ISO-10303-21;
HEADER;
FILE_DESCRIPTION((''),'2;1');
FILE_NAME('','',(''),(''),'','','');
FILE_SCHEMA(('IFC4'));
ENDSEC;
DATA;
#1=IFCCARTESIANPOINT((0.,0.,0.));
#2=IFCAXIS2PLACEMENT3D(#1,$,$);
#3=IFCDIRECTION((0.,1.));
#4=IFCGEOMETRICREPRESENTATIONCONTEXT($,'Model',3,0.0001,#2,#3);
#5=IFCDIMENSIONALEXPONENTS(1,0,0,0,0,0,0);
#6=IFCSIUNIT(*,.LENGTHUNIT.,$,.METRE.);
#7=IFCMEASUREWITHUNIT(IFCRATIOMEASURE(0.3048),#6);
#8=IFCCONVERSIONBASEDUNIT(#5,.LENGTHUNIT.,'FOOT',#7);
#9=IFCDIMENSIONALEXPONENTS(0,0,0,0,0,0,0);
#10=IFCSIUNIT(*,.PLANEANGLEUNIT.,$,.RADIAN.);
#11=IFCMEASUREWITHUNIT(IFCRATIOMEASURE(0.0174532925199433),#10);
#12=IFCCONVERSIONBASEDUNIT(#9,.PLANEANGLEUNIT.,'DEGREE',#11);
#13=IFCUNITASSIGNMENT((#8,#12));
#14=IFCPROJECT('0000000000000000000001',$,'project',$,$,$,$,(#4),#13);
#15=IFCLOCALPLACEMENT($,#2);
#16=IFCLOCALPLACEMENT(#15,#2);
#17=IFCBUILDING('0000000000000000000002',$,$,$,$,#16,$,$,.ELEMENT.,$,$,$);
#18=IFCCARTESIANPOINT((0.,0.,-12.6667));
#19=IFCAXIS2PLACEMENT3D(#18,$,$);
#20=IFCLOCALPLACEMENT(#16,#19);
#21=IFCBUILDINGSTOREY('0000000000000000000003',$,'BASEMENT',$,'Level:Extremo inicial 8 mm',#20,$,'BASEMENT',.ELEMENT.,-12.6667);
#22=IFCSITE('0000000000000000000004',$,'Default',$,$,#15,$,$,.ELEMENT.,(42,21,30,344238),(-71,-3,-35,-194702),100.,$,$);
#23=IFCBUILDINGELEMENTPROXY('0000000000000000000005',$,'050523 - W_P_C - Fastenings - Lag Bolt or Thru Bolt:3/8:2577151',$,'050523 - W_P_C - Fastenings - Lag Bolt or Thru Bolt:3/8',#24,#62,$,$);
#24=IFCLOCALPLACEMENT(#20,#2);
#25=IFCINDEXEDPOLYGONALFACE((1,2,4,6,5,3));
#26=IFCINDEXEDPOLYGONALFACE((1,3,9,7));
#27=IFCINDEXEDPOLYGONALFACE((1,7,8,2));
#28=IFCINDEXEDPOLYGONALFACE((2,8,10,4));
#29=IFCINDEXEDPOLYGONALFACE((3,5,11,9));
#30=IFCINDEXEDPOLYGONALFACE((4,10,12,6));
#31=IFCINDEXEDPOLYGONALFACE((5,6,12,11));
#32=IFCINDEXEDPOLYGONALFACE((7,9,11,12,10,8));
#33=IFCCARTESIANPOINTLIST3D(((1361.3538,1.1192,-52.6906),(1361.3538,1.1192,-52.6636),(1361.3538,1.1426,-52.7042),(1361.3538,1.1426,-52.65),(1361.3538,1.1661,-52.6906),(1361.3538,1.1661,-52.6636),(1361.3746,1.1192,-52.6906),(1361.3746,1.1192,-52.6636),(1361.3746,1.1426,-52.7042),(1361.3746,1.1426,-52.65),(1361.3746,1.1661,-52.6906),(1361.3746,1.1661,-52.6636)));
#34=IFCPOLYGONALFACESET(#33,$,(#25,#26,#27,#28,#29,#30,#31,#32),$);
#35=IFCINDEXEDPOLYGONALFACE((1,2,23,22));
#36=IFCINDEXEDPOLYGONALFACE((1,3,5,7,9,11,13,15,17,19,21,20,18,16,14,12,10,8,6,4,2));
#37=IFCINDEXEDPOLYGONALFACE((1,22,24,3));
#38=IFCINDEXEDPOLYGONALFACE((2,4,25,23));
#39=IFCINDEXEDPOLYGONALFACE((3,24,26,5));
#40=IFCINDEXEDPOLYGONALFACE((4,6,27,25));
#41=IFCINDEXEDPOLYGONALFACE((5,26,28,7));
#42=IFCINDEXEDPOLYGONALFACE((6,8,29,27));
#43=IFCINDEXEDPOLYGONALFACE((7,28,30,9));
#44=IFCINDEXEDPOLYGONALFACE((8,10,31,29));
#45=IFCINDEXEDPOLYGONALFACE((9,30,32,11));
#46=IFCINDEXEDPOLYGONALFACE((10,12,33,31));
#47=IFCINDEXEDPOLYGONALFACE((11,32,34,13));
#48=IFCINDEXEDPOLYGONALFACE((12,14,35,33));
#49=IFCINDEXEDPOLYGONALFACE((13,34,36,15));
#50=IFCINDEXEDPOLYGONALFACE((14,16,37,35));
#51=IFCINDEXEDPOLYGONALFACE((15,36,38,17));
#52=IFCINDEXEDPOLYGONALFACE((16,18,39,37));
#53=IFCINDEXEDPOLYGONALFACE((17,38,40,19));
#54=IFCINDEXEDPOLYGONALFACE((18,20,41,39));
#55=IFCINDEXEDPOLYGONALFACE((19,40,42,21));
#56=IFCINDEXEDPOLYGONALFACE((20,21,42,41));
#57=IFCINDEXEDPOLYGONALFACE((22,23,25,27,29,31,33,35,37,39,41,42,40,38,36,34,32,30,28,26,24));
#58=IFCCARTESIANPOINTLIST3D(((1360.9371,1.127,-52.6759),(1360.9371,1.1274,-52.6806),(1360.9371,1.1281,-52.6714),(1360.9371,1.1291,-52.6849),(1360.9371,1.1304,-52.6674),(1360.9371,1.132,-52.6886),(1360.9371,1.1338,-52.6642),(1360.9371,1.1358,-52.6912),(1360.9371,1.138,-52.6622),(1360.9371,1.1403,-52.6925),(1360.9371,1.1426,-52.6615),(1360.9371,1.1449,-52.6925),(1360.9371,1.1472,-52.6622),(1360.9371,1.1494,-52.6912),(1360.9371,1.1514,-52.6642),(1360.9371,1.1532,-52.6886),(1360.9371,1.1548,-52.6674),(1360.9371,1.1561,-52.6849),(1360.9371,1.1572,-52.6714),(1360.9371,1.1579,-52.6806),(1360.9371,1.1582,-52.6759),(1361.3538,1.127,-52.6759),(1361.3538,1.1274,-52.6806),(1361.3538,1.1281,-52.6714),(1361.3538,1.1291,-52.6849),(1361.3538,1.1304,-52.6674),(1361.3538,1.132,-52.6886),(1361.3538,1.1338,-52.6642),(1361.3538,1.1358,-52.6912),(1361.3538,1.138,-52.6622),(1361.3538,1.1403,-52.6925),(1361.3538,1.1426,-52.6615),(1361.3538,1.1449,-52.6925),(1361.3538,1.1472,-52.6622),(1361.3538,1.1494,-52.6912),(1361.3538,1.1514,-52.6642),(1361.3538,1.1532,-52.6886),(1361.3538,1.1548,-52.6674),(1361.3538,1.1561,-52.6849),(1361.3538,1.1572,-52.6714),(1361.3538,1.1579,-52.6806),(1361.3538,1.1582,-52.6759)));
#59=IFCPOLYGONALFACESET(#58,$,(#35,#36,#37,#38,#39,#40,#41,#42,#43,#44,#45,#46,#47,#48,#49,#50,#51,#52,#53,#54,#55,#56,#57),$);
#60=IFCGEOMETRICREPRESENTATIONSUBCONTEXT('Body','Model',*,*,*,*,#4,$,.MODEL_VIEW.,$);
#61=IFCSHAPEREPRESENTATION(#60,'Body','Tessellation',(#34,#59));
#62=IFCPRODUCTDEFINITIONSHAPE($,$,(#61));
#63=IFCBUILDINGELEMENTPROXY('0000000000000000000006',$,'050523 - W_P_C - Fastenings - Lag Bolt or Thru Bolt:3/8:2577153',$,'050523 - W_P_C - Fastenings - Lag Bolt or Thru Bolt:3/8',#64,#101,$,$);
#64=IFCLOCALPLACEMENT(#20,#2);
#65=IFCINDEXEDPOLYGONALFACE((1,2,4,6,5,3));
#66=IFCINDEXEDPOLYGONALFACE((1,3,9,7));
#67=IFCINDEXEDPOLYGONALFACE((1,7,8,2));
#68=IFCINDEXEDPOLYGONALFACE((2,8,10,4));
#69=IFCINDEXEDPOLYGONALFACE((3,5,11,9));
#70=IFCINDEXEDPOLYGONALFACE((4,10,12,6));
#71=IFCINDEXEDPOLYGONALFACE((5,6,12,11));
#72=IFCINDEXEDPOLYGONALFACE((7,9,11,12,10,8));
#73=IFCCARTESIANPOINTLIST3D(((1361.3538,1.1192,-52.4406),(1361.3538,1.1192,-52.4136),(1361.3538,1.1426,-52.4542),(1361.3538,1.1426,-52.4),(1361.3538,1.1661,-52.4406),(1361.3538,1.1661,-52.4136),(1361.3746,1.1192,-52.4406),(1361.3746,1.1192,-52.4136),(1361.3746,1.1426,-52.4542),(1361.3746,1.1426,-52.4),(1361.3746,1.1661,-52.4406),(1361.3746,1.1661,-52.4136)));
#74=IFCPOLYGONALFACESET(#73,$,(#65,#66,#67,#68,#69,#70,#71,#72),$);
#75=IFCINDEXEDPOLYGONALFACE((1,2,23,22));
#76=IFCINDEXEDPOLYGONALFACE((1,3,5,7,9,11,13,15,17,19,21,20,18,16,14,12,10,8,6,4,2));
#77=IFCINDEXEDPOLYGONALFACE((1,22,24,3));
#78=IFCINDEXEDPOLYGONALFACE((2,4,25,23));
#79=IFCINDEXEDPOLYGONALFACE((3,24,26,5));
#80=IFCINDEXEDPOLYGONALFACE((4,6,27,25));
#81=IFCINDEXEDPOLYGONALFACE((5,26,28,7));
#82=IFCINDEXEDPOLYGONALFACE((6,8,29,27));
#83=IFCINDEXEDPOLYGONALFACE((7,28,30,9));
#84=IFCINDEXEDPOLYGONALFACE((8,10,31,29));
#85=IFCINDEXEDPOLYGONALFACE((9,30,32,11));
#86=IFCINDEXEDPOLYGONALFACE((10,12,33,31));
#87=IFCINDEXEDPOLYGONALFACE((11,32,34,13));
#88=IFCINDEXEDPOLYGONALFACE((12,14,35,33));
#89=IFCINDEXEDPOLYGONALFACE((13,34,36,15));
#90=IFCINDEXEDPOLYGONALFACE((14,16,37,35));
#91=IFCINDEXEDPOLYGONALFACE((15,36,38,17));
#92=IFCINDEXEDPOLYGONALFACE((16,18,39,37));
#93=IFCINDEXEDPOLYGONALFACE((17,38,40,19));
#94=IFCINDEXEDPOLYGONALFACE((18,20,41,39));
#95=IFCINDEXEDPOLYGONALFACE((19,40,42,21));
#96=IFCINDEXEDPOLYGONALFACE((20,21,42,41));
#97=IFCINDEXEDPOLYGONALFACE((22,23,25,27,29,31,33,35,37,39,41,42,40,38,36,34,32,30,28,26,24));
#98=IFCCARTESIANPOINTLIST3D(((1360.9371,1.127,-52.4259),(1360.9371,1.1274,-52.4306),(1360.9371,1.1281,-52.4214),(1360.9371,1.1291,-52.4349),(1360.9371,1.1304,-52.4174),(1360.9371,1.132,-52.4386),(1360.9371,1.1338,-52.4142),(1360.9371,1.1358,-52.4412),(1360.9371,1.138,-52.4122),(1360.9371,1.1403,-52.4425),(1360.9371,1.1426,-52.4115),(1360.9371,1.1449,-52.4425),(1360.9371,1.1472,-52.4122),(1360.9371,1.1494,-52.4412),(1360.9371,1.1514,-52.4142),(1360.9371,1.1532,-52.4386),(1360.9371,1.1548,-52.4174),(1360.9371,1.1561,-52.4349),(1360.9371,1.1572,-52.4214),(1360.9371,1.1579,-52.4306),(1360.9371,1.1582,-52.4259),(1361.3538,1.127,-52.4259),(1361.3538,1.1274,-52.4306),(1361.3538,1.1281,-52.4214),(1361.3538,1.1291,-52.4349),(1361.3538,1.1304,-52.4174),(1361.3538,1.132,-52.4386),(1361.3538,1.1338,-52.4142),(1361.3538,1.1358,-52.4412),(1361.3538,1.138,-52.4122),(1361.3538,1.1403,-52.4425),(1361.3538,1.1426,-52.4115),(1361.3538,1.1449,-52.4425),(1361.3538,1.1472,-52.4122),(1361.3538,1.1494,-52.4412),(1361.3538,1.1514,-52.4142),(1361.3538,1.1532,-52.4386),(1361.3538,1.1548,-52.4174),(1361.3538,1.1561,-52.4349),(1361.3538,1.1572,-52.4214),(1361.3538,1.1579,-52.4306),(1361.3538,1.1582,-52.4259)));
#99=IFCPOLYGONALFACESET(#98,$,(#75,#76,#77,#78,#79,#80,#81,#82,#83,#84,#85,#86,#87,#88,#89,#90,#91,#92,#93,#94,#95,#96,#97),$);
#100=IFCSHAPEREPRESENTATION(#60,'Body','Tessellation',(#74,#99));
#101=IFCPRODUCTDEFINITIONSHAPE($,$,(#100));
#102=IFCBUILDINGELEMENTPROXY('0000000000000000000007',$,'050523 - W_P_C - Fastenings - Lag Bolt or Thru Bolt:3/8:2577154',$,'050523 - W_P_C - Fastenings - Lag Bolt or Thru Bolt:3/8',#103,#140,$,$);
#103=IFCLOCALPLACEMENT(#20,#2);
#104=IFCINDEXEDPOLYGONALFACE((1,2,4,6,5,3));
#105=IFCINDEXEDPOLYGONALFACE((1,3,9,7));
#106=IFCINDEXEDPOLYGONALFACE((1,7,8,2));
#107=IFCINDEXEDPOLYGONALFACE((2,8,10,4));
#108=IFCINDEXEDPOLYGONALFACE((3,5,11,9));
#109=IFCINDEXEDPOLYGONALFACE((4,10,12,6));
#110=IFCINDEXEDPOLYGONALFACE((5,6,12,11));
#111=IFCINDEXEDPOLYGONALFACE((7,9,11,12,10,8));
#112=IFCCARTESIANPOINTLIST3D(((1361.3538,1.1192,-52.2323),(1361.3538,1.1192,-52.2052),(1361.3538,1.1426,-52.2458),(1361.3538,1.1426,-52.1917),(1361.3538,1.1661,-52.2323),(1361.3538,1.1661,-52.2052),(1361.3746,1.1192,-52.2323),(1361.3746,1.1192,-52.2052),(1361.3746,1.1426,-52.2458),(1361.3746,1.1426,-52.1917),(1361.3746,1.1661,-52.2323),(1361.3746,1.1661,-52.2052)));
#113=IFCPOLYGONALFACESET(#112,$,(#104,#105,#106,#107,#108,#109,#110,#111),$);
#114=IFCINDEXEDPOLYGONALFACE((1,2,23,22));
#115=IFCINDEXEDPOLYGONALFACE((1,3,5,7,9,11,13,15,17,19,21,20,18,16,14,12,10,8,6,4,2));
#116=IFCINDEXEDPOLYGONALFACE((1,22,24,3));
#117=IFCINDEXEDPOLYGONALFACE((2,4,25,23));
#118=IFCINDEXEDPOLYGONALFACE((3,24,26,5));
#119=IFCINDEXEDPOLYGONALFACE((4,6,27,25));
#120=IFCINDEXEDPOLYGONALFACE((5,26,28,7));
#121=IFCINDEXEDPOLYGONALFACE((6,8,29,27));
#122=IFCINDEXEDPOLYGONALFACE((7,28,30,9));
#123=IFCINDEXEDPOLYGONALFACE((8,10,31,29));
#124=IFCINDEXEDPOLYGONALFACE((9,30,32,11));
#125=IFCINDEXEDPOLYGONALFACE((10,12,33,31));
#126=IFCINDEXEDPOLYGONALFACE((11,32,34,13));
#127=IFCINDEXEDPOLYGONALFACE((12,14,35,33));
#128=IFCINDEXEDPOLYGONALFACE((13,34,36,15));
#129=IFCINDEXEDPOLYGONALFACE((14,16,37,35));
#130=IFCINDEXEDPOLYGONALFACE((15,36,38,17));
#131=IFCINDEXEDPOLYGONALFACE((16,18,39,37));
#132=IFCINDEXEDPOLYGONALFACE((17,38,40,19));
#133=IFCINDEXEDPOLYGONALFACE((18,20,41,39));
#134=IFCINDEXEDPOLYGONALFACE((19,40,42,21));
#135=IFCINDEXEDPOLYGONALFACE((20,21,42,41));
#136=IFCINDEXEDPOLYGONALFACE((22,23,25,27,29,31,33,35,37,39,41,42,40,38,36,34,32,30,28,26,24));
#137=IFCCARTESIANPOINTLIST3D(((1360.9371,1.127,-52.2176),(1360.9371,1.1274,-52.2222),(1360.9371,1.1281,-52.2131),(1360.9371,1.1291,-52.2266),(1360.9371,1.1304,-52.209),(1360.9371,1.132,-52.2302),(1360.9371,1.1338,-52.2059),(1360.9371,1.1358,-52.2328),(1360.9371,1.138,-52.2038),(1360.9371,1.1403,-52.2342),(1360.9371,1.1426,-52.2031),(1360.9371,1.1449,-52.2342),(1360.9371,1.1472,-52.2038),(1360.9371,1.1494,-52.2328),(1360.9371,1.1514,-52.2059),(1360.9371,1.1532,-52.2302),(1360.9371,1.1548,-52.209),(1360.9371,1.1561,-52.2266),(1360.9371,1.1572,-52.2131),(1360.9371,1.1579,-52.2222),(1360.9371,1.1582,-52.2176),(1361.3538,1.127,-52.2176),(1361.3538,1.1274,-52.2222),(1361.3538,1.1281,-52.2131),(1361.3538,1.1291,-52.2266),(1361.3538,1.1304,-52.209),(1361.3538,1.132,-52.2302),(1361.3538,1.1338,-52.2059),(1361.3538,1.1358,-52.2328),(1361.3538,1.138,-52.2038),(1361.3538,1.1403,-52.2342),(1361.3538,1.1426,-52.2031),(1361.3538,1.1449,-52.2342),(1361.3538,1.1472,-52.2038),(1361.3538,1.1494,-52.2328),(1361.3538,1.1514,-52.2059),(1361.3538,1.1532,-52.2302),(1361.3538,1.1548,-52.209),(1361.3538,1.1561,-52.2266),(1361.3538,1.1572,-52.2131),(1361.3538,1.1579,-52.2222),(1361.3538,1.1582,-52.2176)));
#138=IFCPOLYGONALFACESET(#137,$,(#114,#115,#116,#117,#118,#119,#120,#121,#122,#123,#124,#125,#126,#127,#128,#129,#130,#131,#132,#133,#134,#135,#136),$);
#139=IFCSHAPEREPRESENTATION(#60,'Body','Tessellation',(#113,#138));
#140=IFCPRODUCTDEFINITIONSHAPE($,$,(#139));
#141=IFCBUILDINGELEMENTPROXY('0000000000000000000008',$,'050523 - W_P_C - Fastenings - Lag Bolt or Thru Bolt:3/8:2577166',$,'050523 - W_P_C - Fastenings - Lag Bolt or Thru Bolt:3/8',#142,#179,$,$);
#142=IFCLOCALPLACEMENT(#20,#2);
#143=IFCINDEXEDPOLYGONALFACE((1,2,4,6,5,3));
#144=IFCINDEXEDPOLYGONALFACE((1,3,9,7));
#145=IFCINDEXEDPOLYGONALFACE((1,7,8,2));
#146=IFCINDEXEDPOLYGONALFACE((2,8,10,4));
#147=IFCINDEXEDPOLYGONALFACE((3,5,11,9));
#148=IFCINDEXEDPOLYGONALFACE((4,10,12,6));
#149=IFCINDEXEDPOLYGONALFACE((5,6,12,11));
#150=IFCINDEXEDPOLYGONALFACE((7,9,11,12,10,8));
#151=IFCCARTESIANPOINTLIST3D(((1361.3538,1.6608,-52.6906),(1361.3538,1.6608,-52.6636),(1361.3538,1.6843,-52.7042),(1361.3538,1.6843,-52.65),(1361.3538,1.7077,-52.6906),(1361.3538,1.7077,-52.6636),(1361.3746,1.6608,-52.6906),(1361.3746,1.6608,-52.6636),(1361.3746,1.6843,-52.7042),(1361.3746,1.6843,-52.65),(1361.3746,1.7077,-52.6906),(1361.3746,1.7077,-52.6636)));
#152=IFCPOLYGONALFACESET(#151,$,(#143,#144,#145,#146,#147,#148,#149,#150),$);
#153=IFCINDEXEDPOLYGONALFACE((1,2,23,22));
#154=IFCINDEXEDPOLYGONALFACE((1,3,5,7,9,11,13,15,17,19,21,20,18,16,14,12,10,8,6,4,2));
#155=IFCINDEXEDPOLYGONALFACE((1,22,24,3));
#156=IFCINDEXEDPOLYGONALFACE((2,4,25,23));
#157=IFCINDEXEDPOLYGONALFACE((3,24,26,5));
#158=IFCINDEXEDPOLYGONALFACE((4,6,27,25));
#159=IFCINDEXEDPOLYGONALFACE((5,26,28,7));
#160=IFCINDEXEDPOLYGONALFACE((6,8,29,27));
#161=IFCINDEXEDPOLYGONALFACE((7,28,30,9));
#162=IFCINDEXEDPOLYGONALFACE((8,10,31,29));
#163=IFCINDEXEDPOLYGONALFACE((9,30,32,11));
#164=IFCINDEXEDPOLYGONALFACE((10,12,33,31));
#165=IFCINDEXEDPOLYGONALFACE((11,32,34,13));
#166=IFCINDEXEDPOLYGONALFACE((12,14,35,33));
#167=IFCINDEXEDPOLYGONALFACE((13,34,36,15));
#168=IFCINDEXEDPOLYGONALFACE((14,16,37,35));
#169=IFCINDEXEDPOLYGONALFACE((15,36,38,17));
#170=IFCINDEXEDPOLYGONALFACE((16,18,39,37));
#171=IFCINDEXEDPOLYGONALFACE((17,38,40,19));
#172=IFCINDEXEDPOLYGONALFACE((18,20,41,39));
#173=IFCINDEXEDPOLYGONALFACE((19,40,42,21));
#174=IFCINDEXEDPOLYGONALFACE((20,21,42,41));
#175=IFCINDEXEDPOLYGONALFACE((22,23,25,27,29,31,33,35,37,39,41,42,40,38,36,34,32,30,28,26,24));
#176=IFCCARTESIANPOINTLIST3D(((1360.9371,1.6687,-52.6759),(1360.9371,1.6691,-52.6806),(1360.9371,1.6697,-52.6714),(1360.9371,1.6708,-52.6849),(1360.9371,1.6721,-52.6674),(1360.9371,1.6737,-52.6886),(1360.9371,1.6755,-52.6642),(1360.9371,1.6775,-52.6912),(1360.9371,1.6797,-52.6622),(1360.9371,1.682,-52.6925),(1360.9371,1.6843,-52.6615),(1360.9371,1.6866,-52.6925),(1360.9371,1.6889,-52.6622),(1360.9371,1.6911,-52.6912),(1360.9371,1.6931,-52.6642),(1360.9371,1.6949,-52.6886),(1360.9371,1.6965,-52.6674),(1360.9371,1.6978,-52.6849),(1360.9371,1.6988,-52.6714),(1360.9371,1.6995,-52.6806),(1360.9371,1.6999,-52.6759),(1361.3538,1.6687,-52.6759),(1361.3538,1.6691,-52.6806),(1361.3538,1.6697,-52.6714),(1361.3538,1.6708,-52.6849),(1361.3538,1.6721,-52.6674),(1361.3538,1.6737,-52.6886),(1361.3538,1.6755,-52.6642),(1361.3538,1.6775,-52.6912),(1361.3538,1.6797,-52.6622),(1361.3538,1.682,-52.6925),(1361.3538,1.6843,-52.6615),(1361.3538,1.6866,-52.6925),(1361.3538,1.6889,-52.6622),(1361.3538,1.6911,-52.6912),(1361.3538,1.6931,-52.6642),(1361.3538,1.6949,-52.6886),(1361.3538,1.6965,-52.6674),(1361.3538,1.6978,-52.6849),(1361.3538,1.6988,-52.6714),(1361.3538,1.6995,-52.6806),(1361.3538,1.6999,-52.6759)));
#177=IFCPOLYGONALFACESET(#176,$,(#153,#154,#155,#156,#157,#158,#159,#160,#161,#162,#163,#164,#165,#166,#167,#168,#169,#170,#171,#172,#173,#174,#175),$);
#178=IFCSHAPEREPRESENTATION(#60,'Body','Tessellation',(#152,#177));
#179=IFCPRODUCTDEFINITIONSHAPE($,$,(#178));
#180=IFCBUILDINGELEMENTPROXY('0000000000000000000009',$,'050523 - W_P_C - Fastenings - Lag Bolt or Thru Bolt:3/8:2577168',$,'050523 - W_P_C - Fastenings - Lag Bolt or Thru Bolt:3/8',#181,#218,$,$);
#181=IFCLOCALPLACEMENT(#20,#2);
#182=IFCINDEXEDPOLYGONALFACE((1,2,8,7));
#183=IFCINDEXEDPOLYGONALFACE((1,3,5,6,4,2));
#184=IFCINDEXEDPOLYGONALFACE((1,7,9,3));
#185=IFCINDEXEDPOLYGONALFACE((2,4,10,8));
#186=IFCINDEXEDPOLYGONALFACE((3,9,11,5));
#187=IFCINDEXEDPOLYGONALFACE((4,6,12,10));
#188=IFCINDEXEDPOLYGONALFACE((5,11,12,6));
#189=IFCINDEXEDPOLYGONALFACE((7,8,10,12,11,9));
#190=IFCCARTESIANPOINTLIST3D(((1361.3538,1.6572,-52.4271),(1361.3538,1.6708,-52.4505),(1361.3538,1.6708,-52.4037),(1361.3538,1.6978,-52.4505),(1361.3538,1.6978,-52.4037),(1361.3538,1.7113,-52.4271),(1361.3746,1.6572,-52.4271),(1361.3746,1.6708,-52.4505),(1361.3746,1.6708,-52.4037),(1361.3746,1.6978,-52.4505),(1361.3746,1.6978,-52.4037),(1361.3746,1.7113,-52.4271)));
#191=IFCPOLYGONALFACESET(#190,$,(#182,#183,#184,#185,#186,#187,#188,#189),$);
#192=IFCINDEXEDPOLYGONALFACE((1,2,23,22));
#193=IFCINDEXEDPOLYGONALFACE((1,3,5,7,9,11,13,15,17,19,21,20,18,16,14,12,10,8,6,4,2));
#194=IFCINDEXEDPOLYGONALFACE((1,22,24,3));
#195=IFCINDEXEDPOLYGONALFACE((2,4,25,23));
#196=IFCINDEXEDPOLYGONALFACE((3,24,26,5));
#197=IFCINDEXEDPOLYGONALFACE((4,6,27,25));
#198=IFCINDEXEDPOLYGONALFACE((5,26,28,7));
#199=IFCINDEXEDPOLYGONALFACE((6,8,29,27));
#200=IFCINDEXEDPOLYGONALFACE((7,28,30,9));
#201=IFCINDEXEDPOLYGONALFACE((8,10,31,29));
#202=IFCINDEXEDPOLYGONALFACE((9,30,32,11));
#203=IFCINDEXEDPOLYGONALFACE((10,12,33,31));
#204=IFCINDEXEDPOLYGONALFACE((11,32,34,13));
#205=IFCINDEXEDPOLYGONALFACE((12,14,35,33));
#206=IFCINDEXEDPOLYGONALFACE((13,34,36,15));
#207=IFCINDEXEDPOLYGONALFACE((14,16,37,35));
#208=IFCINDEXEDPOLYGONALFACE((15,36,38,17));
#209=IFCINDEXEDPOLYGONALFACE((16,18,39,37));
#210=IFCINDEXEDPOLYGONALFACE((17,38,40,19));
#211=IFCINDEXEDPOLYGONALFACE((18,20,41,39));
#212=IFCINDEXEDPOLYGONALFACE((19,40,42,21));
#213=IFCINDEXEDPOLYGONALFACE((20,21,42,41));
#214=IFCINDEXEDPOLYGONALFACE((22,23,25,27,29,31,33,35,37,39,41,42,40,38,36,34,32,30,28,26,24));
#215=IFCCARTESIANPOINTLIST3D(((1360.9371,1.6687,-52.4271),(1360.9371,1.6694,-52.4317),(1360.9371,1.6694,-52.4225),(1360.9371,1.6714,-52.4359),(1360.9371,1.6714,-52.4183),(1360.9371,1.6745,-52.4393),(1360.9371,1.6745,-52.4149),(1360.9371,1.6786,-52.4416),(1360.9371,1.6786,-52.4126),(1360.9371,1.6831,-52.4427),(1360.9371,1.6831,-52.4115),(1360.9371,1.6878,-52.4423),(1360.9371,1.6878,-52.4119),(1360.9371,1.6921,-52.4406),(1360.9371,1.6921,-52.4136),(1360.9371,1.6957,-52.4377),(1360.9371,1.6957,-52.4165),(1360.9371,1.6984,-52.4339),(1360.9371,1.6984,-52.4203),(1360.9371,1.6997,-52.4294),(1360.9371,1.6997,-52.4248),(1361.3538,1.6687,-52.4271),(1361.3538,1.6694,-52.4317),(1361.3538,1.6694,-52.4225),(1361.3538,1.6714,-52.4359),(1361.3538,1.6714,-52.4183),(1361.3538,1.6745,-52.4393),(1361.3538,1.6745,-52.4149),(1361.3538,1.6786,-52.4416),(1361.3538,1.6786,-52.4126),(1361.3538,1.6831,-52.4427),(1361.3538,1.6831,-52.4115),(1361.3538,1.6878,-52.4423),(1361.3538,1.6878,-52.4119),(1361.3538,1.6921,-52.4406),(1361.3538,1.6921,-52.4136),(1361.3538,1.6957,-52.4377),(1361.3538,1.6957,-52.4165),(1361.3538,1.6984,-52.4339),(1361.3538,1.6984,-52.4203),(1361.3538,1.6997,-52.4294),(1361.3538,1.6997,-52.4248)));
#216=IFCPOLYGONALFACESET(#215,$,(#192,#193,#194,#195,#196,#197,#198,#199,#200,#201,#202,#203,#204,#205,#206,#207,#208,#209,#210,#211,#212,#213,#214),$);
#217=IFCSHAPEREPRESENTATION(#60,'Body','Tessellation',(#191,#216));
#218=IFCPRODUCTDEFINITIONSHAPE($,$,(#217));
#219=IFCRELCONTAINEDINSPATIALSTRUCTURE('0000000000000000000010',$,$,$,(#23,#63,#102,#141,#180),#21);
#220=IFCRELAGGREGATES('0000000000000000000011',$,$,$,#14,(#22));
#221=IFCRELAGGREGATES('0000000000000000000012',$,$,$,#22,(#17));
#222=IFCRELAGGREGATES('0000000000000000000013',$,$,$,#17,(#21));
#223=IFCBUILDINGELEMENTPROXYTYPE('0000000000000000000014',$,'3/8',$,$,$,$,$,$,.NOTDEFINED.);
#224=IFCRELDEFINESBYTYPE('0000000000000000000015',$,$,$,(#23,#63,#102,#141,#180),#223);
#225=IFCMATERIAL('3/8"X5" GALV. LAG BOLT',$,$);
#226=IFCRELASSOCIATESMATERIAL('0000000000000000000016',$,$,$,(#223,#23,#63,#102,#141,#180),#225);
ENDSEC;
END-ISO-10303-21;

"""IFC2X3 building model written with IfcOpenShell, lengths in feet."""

from ifc_helpers import new_model, entity, si_unit, converted_unit, direction, frame, frame_2d, origin, place, context, subcontext, project, spatial, polyline, circle, outline, extrude, source, transform, mapped, material, type_object, type_shapes, element, save


model = new_model("IFC2X3")

# Units and contexts
model_context = context("Model", 3, precision=0.0001, world=origin(), true_north=direction((0.0, 1.0)))
body_context = subcontext(model_context, "Body", "Model", "MODEL_VIEW")
ifc_project = project(units=[converted_unit("LENGTHUNIT", "FOOT", entity("IfcRatioMeasure", 0.3048), si_unit("LENGTHUNIT", "METRE"), dimensions=[1, 0, 0, 0, 0, 0, 0]), converted_unit("PLANEANGLEUNIT", "DEGREE", entity("IfcRatioMeasure", 0.0174532925199433), si_unit("PLANEANGLEUNIT", "RADIAN"), dimensions=[0, 0, 0, 0, 0, 0, 0])], contexts=[model_context])

# Site, building, storey
site_placement = place(None, origin())
site = spatial("IfcSite", under=ifc_project, at=site_placement, Name="Default", CompositionType="ELEMENT", RefLatitude=(42, 21, 30, 344238), RefLongitude=(-71, -3, -35, -194702), RefElevation=100.0)
building_placement = place(site_placement, origin())
building = spatial("IfcBuilding", under=site, at=building_placement, CompositionType="ELEMENT")
storey_placement = place(building_placement, frame((0.0, 0.0, -12.6667)))
storey = spatial("IfcBuildingStorey", under=building, at=storey_placement, Name="BASEMENT", ObjectType="Level:Extremo inicial 8 mm", LongName="BASEMENT", CompositionType="ELEMENT", Elevation=-12.6667)

# Building element proxies
ifc_material = material(Name="3/8\"X5\" GALV. LAG BOLT")
building_element_proxy_type = type_object("IfcBuildingElementProxyType", Name="3/8", PredefinedType="NOTDEFINED", material=ifc_material)
shared_shape = source(origin(), body_context, "Body", "SweptSolid", [
    extrude(outline(polyline([(-0.0135, -0.0234), (0.0135, -0.0234), (0.0271, 0.0), (0.0135, 0.0234), (-0.0135, 0.0234), (-0.0271, 0.0), (-0.0135, -0.0234)])), frame((0.0, 0.0, 0.0), z_axis=(0.0, 0.0, 1.0), x_axis=(0.0, -1.0, 0.0)), (0.0, 0.0, 1.0), 0.0208),
    extrude(circle(Radius=0.0156, at=frame_2d((0.0, 0.0), x_axis=(1.0, 0.0))), frame((0.0, 0.0, -0.4167), z_axis=(0.0, 0.0, 1.0), x_axis=(0.0, 1.0, 0.0)), (0.0, 0.0, 1.0), 0.4167),
])
type_shapes(building_element_proxy_type, [shared_shape])
for number, where, z_axis, x_axis, name in (
    (1, (1361.3538, 1.1426, -52.6771), (1.0, 0.0, 0.0), (0.0, 1.0, 0.0), "050523 - W_P_C - Fastenings - Lag Bolt or Thru Bolt:3/8:2577151"),
    (2, (1361.3538, 1.1426, -52.4271), (1.0, 0.0, 0.0), (0.0, 1.0, 0.0), "050523 - W_P_C - Fastenings - Lag Bolt or Thru Bolt:3/8:2577153"),
    (3, (1361.3538, 1.1426, -52.2188), (1.0, 0.0, 0.0), (0.0, 1.0, 0.0), "050523 - W_P_C - Fastenings - Lag Bolt or Thru Bolt:3/8:2577154"),
    (4, (1361.3538, 1.6843, -52.6771), (1.0, 0.0, 0.0), (0.0, 1.0, 0.0), "050523 - W_P_C - Fastenings - Lag Bolt or Thru Bolt:3/8:2577166"),
    (5, (1361.3538, 1.6843, -52.4271), (1.0, 0.0, 0.0), (0.0, 0.0, 1.0), "050523 - W_P_C - Fastenings - Lag Bolt or Thru Bolt:3/8:2577168"),
):
    element("IfcBuildingElementProxy", number, at=place(storey_placement, frame(where, z_axis=z_axis, x_axis=x_axis)), inside=storey, type_object=building_element_proxy_type, material=ifc_material, Name=name, ObjectType="050523 - W_P_C - Fastenings - Lag Bolt or Thru Bolt:3/8", context=body_context, shape_type="MappedRepresentation", body=[
        mapped(shared_shape, transform((0.0, 0.0, 0.0), scale=1.0)),
    ])

save(model, "model.ifc")
